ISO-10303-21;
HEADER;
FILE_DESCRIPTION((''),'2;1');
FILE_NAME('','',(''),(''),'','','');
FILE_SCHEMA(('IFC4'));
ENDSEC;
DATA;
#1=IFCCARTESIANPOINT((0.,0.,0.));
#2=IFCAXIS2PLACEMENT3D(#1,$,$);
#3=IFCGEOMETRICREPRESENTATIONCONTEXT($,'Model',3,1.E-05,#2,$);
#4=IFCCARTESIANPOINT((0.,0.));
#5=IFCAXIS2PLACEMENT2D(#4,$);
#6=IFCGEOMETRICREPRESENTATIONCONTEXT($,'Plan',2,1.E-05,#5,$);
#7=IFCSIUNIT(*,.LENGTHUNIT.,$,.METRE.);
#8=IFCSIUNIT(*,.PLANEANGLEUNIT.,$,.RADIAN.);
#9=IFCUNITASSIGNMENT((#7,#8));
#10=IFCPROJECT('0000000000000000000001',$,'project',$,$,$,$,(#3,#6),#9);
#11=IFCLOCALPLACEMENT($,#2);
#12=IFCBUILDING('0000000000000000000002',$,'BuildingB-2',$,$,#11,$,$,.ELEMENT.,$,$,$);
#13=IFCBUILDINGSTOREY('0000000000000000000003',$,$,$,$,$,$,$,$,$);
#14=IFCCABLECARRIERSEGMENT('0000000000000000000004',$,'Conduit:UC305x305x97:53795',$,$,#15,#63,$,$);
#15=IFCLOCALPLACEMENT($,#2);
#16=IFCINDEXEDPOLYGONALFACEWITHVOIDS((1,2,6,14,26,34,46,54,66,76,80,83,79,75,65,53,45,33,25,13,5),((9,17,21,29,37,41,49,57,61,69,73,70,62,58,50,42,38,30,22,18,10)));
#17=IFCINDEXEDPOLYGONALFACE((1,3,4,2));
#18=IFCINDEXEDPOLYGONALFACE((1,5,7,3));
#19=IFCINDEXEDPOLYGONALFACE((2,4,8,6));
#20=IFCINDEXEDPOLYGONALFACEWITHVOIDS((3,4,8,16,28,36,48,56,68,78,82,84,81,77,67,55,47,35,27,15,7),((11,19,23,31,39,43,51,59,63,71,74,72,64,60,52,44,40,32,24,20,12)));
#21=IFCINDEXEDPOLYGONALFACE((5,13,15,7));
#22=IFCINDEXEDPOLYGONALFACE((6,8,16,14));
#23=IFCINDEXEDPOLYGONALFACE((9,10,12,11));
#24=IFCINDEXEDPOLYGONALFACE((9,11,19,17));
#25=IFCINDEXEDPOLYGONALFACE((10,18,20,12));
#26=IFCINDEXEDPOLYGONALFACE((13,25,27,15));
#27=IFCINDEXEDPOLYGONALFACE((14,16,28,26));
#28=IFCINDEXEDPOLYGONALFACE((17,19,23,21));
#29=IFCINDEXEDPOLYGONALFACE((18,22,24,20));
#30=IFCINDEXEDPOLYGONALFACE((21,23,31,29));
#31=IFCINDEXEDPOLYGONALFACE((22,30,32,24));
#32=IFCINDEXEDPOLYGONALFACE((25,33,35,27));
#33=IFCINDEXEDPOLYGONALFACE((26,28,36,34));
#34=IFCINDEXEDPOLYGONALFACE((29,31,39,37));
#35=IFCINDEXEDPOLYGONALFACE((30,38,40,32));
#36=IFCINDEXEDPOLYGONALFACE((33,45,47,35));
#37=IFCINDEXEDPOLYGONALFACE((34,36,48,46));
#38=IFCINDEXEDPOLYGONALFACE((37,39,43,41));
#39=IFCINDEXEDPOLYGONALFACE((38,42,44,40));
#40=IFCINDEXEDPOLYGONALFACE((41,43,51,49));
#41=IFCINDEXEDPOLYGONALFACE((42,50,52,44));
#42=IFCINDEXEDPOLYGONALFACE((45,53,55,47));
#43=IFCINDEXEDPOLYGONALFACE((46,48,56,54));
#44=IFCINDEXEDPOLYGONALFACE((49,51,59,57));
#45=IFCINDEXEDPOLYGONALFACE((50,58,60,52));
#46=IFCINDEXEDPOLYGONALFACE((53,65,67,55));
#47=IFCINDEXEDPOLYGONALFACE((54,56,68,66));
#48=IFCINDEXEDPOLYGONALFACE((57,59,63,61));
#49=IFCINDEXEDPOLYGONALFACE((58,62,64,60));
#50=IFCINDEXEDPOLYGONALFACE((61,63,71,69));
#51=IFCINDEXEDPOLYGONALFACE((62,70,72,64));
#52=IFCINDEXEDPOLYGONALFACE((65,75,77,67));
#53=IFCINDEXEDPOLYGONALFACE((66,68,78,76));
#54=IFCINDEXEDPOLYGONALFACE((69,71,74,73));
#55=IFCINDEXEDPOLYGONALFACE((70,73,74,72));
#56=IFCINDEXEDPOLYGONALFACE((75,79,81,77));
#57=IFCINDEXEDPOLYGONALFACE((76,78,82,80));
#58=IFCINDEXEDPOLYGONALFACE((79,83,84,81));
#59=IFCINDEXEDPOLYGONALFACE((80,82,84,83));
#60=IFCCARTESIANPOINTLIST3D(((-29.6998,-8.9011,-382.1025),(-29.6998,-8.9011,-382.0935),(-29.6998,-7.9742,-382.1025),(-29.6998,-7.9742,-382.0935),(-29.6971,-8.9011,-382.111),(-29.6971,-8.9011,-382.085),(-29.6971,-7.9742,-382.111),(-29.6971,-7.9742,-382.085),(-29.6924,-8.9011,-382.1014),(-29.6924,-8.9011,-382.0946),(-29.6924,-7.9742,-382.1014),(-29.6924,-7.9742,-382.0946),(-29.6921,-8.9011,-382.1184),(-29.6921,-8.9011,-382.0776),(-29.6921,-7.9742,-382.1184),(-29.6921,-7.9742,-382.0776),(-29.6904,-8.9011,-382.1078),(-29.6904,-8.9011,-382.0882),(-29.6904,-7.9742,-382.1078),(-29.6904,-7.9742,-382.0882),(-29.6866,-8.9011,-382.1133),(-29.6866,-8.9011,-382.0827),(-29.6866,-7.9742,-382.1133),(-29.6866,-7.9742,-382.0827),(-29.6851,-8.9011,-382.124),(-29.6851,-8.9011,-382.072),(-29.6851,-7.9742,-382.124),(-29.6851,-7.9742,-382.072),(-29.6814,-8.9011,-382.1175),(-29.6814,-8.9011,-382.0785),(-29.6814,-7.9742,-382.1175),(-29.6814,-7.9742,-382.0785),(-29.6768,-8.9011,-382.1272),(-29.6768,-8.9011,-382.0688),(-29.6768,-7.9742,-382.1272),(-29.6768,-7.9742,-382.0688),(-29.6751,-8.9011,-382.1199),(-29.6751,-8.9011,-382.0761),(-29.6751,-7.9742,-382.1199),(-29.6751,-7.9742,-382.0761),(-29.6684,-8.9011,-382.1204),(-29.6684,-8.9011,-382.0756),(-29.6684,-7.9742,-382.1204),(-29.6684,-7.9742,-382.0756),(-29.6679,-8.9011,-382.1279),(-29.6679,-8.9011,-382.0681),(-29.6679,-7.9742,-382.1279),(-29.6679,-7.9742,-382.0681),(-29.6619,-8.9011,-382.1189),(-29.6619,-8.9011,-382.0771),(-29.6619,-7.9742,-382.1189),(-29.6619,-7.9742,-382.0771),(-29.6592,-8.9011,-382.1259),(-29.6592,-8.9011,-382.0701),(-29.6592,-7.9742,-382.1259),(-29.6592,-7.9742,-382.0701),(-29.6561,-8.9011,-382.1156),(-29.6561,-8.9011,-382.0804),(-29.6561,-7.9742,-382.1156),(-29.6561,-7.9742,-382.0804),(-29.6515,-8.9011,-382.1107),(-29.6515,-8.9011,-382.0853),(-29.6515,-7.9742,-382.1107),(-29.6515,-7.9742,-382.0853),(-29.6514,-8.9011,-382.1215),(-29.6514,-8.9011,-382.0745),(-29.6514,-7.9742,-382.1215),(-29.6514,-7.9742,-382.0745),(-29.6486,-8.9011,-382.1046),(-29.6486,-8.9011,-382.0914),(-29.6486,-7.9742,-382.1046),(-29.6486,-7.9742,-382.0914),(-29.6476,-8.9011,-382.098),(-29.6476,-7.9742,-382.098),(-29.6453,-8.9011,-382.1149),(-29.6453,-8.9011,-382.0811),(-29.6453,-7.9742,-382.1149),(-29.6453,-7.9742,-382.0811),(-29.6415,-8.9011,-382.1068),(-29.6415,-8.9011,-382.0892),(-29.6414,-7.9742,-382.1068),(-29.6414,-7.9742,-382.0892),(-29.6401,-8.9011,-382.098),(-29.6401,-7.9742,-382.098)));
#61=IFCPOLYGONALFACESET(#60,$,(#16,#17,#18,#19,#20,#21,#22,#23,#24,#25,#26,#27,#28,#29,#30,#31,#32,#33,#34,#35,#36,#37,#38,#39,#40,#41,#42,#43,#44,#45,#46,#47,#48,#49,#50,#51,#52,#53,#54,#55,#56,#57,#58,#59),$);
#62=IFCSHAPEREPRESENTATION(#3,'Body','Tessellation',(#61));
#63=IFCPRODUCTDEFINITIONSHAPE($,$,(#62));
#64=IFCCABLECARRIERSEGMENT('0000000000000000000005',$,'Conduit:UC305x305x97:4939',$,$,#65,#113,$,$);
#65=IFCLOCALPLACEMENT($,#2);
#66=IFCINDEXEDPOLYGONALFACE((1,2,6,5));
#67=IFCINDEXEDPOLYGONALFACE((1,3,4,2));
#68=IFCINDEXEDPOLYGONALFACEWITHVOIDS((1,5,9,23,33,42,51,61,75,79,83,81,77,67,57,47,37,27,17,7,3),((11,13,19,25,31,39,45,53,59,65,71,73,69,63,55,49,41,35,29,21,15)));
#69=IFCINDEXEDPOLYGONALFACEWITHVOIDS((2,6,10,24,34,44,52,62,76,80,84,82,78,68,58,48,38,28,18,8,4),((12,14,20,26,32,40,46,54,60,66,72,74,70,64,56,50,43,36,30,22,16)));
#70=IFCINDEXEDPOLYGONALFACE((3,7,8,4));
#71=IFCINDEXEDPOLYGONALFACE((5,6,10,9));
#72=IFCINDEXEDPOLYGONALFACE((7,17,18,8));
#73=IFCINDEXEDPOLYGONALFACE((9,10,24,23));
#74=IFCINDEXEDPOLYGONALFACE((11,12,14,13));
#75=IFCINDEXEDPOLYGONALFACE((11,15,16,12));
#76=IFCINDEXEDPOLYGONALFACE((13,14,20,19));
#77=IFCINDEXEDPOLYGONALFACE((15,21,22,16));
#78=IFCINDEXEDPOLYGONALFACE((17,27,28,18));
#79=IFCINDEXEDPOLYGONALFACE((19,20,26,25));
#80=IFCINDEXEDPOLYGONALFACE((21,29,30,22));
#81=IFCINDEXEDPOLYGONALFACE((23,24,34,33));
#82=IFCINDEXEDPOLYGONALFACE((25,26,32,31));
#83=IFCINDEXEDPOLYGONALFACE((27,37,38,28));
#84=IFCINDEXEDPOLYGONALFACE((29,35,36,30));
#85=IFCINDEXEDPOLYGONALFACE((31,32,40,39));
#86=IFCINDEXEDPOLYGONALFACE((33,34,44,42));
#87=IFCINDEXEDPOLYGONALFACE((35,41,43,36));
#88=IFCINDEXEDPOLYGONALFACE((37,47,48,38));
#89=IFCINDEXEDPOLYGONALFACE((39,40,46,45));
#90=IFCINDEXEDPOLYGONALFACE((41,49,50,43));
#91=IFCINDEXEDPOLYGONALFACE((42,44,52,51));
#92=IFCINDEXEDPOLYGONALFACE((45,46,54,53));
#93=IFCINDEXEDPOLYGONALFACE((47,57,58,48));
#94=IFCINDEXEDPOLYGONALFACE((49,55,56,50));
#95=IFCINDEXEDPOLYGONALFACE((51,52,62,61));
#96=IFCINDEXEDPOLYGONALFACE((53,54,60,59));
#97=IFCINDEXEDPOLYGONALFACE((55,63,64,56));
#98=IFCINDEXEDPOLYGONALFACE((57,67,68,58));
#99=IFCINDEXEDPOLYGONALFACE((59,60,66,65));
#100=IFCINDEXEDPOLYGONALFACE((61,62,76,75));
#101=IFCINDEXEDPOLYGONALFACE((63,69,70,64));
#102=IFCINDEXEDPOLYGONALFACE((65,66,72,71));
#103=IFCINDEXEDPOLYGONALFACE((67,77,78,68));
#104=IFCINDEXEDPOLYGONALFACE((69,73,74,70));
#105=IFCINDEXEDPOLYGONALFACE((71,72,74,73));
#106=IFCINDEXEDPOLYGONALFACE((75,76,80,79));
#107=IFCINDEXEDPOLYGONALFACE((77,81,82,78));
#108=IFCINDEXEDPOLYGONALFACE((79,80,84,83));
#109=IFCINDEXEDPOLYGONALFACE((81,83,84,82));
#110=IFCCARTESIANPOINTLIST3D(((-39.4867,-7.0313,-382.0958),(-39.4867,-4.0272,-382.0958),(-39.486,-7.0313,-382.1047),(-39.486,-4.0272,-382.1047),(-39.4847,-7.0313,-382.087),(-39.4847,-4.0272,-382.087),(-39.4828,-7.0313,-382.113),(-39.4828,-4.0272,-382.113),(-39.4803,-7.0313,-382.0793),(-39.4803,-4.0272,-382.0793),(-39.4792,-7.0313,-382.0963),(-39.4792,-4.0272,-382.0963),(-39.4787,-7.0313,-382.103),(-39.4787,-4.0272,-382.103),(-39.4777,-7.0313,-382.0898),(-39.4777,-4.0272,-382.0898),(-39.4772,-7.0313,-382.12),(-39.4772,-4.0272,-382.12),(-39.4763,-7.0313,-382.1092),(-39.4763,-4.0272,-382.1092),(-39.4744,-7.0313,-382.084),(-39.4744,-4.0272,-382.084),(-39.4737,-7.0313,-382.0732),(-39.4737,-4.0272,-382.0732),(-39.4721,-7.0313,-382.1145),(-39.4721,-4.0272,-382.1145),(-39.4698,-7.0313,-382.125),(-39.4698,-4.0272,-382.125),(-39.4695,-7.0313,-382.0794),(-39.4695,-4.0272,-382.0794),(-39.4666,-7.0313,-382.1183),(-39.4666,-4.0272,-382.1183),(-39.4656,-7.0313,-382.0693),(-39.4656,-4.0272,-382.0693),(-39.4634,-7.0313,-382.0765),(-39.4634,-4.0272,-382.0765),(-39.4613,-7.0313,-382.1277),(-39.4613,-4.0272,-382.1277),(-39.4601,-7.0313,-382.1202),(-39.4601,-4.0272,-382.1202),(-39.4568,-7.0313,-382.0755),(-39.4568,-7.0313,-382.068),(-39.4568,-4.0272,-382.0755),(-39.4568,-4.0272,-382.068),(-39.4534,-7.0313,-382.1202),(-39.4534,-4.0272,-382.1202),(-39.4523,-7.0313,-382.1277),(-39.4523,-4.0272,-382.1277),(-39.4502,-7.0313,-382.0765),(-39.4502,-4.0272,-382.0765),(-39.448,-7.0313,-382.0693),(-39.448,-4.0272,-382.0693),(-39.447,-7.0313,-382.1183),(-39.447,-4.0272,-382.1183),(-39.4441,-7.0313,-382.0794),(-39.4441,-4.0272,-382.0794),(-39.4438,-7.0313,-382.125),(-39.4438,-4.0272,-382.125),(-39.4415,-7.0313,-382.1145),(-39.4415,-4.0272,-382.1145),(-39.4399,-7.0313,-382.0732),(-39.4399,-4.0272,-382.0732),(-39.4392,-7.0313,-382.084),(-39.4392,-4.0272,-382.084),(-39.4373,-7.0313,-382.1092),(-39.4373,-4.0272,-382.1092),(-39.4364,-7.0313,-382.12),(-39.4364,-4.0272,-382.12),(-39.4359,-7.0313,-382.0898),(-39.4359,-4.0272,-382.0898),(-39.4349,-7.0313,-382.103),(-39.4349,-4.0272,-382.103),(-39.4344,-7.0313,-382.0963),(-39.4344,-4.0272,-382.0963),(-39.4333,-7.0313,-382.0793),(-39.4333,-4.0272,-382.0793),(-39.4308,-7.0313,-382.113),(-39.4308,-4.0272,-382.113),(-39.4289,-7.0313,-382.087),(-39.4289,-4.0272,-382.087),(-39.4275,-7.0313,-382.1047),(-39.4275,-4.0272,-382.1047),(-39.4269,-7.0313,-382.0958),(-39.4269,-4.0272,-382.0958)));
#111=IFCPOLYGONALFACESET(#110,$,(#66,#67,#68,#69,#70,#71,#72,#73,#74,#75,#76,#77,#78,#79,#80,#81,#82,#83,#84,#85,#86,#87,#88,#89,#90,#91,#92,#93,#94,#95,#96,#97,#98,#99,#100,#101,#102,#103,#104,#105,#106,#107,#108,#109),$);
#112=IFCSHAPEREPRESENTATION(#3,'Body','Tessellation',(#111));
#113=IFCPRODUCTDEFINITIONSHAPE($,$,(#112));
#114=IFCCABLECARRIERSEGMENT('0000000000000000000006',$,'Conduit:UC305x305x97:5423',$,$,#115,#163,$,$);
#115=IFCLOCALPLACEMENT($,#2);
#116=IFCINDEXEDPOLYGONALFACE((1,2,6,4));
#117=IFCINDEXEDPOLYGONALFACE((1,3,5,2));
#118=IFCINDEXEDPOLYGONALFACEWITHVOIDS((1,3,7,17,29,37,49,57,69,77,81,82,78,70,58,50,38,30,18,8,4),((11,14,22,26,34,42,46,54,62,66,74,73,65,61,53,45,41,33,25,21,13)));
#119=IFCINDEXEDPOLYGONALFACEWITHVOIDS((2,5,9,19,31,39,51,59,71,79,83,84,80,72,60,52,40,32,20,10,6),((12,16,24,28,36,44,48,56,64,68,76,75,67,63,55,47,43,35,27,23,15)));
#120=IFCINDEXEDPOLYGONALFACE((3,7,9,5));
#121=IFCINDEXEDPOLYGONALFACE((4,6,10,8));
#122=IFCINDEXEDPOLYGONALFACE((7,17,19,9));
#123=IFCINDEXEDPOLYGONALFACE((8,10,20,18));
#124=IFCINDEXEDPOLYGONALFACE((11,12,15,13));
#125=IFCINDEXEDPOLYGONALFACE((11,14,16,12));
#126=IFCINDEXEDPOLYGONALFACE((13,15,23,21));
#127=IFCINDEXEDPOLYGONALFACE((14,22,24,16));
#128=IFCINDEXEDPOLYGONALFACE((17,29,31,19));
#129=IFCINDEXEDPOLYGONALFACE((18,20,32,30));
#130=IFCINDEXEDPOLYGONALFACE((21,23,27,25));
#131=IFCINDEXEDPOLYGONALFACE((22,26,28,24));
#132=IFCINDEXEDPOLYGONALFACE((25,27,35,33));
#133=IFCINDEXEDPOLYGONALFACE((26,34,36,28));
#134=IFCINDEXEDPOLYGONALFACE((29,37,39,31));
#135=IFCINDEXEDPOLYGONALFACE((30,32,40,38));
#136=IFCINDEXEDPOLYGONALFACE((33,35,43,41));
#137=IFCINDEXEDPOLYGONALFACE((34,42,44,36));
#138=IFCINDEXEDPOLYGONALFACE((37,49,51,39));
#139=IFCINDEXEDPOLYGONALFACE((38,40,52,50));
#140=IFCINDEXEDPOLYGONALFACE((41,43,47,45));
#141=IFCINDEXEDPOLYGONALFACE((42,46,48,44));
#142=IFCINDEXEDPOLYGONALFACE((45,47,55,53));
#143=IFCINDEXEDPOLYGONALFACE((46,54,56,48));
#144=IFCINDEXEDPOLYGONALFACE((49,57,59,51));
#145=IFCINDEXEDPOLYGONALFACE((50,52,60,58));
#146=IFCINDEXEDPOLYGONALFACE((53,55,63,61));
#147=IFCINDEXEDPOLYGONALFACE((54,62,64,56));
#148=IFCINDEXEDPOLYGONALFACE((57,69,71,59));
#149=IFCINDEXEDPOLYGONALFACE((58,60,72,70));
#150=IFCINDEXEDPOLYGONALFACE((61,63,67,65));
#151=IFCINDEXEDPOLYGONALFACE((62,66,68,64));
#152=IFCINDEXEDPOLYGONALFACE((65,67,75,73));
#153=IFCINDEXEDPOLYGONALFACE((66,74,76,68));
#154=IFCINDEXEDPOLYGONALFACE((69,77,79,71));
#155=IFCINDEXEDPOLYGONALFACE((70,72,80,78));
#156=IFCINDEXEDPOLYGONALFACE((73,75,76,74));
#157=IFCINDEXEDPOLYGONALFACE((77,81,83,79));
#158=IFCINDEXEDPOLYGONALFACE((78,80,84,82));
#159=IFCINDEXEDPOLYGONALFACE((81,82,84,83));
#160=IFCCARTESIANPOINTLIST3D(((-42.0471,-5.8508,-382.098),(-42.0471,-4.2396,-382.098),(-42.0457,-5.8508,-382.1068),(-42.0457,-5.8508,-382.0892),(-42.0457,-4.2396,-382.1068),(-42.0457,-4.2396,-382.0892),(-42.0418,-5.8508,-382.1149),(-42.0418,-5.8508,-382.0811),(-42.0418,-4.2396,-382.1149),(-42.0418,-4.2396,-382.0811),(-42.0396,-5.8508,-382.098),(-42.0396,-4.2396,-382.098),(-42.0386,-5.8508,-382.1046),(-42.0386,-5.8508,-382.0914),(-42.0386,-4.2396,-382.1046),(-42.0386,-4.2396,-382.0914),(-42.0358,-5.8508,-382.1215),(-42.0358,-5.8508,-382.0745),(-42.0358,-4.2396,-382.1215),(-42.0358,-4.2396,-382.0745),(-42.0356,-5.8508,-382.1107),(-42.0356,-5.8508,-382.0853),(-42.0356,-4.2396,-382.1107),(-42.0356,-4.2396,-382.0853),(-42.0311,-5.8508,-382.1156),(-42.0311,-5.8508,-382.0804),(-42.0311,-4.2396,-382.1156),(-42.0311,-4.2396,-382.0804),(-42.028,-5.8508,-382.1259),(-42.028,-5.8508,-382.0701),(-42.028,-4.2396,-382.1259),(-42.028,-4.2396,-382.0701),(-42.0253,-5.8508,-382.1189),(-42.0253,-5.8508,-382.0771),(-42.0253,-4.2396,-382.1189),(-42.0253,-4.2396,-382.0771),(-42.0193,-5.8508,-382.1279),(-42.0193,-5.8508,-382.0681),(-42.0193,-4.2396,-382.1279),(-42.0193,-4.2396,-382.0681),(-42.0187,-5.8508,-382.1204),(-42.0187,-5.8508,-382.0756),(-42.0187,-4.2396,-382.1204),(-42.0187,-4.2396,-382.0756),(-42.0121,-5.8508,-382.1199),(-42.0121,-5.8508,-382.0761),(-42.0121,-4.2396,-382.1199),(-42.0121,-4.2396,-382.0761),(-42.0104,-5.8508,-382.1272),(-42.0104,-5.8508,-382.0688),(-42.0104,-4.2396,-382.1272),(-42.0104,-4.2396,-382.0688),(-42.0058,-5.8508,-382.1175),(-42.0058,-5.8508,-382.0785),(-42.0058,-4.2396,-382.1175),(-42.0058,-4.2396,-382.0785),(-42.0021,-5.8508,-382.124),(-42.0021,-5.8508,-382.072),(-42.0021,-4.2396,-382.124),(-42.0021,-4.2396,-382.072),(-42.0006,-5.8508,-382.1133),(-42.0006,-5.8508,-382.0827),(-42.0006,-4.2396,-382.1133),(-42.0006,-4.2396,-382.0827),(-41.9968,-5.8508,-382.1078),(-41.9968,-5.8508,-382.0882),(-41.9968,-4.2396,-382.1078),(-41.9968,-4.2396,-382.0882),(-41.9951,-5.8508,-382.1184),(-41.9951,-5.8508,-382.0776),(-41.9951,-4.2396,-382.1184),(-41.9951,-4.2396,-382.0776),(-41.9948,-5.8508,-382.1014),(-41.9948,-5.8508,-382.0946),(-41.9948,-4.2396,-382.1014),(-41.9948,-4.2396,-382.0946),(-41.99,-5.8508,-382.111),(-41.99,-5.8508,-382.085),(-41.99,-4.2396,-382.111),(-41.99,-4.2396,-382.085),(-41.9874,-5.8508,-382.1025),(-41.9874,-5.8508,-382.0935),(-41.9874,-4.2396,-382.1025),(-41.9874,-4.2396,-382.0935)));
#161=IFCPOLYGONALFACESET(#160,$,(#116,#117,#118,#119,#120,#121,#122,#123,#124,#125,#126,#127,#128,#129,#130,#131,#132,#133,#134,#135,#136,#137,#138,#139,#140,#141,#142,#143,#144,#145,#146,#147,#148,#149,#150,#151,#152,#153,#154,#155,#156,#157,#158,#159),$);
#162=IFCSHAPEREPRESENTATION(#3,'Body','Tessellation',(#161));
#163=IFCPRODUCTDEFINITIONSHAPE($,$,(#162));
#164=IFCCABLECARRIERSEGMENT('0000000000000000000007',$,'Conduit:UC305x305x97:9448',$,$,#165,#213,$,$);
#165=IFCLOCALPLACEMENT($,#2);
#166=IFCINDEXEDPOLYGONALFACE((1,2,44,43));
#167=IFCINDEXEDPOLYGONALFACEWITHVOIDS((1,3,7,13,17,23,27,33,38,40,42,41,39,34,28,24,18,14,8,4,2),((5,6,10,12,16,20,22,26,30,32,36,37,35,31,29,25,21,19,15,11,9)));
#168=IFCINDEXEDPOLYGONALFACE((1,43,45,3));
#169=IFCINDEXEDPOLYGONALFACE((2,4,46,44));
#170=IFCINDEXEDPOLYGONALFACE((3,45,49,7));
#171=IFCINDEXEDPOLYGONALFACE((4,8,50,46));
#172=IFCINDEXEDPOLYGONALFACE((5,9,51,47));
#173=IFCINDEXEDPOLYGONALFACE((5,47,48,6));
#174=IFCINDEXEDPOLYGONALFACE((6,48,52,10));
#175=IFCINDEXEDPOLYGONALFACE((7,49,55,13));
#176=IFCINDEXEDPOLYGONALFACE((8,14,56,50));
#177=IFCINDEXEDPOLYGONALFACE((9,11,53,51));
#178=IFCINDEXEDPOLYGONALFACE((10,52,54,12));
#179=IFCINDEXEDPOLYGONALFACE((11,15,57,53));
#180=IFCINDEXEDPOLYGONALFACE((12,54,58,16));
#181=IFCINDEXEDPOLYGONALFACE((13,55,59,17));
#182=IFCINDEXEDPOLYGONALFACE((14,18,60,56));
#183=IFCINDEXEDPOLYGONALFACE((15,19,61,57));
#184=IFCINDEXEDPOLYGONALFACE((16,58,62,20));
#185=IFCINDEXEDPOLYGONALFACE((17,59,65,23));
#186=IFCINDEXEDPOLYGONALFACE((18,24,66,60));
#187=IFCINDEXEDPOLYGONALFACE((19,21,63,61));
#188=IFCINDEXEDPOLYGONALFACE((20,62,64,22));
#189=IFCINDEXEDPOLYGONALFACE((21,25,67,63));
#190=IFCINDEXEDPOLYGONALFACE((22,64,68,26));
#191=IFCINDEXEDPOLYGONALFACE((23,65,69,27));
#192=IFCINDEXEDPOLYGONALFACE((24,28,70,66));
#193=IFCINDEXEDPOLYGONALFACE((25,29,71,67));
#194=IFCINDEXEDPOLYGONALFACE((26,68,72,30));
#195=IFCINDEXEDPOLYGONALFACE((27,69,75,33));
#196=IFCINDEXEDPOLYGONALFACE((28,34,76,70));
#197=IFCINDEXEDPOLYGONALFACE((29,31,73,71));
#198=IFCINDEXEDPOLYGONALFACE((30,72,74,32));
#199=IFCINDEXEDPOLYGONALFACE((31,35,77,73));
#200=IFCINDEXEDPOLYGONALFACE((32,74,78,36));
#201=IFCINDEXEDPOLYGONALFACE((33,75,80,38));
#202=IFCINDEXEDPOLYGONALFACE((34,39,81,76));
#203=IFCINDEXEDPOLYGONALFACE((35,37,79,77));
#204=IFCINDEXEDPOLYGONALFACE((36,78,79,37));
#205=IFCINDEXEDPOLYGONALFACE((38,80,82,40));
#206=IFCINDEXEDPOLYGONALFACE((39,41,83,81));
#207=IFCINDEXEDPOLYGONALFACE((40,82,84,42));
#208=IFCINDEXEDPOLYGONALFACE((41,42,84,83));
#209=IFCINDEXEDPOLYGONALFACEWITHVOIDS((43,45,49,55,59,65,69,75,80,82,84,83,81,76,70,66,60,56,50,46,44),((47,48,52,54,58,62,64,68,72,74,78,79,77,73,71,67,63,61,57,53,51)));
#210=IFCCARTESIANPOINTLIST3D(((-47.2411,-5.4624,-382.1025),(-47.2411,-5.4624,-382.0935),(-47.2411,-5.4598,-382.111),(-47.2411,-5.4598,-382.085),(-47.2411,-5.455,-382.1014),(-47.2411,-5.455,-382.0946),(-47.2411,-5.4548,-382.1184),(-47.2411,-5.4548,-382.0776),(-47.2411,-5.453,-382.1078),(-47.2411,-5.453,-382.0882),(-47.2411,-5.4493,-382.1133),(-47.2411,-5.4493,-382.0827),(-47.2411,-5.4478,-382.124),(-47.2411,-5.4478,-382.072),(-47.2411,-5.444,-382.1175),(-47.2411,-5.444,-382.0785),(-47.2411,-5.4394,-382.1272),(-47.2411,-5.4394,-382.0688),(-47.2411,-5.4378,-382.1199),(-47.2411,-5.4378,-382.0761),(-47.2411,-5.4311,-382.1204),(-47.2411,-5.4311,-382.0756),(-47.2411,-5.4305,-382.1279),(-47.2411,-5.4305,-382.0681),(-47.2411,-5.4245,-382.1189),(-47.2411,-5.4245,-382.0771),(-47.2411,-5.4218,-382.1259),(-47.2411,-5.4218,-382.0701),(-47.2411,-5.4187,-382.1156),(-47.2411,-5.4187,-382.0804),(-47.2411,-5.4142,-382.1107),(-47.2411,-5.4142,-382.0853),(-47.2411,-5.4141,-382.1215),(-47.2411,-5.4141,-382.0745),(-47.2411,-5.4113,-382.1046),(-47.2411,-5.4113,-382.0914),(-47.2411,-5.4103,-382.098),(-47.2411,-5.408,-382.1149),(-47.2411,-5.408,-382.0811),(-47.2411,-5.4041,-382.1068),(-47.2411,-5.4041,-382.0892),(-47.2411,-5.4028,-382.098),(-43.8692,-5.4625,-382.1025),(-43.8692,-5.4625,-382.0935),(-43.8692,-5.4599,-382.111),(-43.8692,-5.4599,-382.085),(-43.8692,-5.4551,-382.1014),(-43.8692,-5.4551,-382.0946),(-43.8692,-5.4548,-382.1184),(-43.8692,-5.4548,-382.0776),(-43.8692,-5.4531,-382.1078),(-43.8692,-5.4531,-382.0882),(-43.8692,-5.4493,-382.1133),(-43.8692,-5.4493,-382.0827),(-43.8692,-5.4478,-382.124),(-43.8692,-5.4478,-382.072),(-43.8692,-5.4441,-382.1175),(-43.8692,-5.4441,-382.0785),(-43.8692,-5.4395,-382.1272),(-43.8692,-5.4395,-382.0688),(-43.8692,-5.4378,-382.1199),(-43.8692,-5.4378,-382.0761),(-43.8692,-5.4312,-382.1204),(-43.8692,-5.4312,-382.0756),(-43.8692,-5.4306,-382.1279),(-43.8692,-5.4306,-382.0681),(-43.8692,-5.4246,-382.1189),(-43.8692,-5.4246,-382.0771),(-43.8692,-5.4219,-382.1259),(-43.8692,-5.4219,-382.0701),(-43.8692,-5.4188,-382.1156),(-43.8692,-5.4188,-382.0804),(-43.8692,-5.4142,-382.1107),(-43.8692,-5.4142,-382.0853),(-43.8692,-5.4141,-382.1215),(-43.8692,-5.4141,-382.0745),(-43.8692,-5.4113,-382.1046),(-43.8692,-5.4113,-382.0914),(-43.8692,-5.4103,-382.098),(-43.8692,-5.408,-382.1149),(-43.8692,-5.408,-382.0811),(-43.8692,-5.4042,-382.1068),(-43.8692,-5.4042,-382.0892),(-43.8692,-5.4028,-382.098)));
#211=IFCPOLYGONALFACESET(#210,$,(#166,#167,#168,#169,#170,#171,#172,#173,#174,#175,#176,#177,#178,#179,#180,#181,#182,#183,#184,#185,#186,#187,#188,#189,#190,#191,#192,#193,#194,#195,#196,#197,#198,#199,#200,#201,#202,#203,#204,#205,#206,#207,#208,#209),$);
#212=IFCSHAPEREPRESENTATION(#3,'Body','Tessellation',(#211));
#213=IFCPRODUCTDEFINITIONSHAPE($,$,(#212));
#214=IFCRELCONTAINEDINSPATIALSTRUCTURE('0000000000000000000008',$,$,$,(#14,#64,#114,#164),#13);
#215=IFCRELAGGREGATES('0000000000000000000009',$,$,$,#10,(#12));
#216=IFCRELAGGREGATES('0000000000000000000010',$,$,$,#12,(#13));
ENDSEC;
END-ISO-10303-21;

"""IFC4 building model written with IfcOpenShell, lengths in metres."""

from ifc_helpers import new_model, entity, si_unit, origin, origin_2d, place, context, project, spatial, element, save


model = new_model("IFC4")

# Units and contexts
model_context = context("Model", 3, precision=1e-05, world=origin())
plan_context = context("Plan", 2, precision=1e-05, world=origin_2d())
ifc_project = project(units=[si_unit("LENGTHUNIT", "METRE"), si_unit("PLANEANGLEUNIT", "RADIAN")], contexts=[model_context, plan_context])

# Building, storey
building_placement = place(None, origin())
building = spatial("IfcBuilding", under=ifc_project, at=building_placement, Name="BuildingB-2", CompositionType="ELEMENT")
storey = spatial("IfcBuildingStorey", under=building)

# Cable carrier segments
element("IfcCableCarrierSegment", 1, inside=storey, Name="Conduit:UC305x305x97:53795", context=model_context, shape_type="AdvancedSweptSolid", body=[
    entity("IfcSweptDiskSolid", entity("IfcCompositeCurve", [entity("IfcCompositeCurveSegment", "CONTINUOUS", False, entity("IfcPolyline", [entity("IfcCartesianPoint", [29.6701, 7.9742, 382.098]), entity("IfcCartesianPoint", [29.6701, 8.9011, 382.098])]))], False), 0.03, 0.0225),
])
element("IfcCableCarrierSegment", 2, inside=storey, Name="Conduit:UC305x305x97:4939", context=model_context, shape_type="AdvancedSweptSolid", body=[
    entity("IfcSweptDiskSolid", entity("IfcCompositeCurve", [entity("IfcCompositeCurveSegment", "CONTINUOUS", False, entity("IfcPolyline", [entity("IfcCartesianPoint", [39.4568, 4.0272, 382.098]), entity("IfcCartesianPoint", [39.4568, 7.0313, 382.098])]))], False), 0.03, 0.0225),
])
element("IfcCableCarrierSegment", 3, inside=storey, Name="Conduit:UC305x305x97:5423", context=model_context, shape_type="AdvancedSweptSolid", body=[
    entity("IfcSweptDiskSolid", entity("IfcCompositeCurve", [entity("IfcCompositeCurveSegment", "CONTINUOUS", False, entity("IfcPolyline", [entity("IfcCartesianPoint", [42.0171, 5.8508, 382.098]), entity("IfcCartesianPoint", [42.0171, 4.2396, 382.098])]))], False), 0.03, 0.0225),
])
element("IfcCableCarrierSegment", 4, inside=storey, Name="Conduit:UC305x305x97:9448", context=model_context, shape_type="AdvancedSweptSolid", body=[
    entity("IfcSweptDiskSolid", entity("IfcCompositeCurve", [entity("IfcCompositeCurveSegment", "CONTINUOUS", False, entity("IfcPolyline", [entity("IfcCartesianPoint", [43.8692, 5.4328, 382.098]), entity("IfcCartesianPoint", [47.2411, 5.4328, 382.098])]))], False), 0.03, 0.0225),
])

save(model, "model.ifc")
